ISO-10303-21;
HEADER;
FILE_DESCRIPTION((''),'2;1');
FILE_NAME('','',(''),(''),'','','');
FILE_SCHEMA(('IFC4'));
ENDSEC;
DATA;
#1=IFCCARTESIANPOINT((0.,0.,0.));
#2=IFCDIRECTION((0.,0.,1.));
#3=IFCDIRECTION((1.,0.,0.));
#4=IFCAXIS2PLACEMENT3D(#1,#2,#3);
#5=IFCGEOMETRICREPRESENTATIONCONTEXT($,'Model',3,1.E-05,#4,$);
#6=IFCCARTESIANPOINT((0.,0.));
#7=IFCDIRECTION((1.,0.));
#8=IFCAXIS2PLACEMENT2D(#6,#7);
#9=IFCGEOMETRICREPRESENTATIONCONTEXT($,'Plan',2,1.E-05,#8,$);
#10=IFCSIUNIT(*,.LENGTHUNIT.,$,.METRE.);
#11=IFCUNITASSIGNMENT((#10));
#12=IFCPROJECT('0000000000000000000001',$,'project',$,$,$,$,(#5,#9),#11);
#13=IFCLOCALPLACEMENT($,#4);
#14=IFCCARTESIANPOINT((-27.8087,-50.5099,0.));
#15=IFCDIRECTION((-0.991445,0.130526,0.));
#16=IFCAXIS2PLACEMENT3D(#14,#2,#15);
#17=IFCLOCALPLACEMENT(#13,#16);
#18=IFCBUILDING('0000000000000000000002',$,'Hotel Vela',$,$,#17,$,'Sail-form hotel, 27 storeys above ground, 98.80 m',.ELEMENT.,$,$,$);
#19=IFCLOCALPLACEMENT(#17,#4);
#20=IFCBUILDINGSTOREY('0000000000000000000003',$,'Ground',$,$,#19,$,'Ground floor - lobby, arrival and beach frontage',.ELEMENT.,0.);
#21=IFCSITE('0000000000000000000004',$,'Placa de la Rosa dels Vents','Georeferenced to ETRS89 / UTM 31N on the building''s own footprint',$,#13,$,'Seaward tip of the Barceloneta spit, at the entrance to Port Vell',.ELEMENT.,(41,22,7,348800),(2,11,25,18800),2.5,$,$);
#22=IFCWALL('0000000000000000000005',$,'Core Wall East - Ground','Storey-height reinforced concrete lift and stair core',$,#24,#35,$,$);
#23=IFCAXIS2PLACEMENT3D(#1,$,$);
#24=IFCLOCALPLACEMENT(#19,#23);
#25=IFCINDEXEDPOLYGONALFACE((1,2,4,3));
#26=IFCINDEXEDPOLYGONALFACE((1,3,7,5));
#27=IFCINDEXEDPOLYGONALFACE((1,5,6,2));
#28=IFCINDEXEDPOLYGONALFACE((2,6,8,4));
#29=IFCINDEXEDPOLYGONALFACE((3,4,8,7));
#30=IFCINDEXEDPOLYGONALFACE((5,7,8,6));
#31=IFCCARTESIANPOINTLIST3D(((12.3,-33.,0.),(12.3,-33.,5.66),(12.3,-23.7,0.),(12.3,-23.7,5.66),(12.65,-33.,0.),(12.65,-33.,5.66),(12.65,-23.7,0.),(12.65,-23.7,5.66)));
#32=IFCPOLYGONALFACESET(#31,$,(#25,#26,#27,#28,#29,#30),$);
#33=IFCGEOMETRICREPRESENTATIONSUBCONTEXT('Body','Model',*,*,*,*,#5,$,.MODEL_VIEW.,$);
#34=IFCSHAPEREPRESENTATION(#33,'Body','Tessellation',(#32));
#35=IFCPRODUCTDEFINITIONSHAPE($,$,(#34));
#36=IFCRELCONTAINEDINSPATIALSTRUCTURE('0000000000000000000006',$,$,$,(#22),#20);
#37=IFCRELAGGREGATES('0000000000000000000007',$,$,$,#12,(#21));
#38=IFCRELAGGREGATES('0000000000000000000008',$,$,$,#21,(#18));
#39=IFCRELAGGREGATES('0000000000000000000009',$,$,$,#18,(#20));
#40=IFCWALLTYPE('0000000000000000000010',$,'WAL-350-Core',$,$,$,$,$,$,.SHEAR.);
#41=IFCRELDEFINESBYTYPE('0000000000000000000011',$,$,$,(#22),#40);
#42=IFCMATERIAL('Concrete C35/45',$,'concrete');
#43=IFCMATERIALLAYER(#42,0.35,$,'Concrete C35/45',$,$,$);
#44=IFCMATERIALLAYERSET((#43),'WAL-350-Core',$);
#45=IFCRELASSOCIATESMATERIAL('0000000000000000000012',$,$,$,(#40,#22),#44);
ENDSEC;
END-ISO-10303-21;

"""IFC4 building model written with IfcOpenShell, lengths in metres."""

from ifc_helpers import new_model, si_unit, frame, origin_with_axes, origin_2d_with_axis, place, context, subcontext, project, spatial, line, indexed_curve, outline, extrude, material, layer, layer_set, layer_usage, type_object, element, save


model = new_model("IFC4")

# Units and contexts
model_context = context("Model", 3, precision=1e-05, world=origin_with_axes())
plan_context = context("Plan", 2, precision=1e-05, world=origin_2d_with_axis())
body_context = subcontext(model_context, "Body", "Model", "MODEL_VIEW")
ifc_project = project(units=[si_unit("LENGTHUNIT", "METRE")], contexts=[model_context, plan_context])

# Site, building, storey
site_placement = place(None, origin_with_axes())
site = spatial("IfcSite", under=ifc_project, at=site_placement, Name="Placa de la Rosa dels Vents", Description="Georeferenced to ETRS89 / UTM 31N on the building's own footprint", LongName="Seaward tip of the Barceloneta spit, at the entrance to Port Vell", CompositionType="ELEMENT", RefLatitude=(41, 22, 7, 348800), RefLongitude=(2, 11, 25, 18800), RefElevation=2.5)
building_placement = place(site_placement, frame((-27.8087, -50.5099, 0.0), z_axis=(0.0, 0.0, 1.0), x_axis=(-0.991445, 0.130526, 0.0)))
building = spatial("IfcBuilding", under=site, at=building_placement, Name="Hotel Vela", LongName="Sail-form hotel, 27 storeys above ground, 98.80 m", CompositionType="ELEMENT")
storey_placement = place(building_placement, origin_with_axes())
storey = spatial("IfcBuildingStorey", under=building, at=storey_placement, Name="Ground", LongName="Ground floor - lobby, arrival and beach frontage", CompositionType="ELEMENT", Elevation=0.0)

# Shared definitions
ifc_material = material(Name="Concrete C35/45", Category="concrete")

# Wall
ifc_layer_1 = layer(ifc_material, 0.35, Name="Concrete C35/45")
ifc_layer_set_1 = layer_set([ifc_layer_1], Name="WAL-350-Core")
wall_type = type_object("IfcWallType", Name="WAL-350-Core", PredefinedType="SHEAR", material=ifc_layer_set_1)
ifc_layer_usage_1 = layer_usage(ifc_layer_set_1, "AXIS2", "POSITIVE", 0.0)
wall_1_placement = place(storey_placement, frame((12.65, -33.0, 0.0), z_axis=(0.0, 0.0, 1.0), x_axis=(0.0, 1.0, 0.0)))
element("IfcWall", 1, at=wall_1_placement, inside=storey, type_object=wall_type, material=ifc_layer_usage_1, Name="Core Wall East - Ground", Description="Storey-height reinforced concrete lift and stair core", context=body_context, shape_type="SweptSolid", body=[
    extrude(outline(indexed_curve([(0.0, 0.0), (9.3, 0.0), (9.3, 0.35), (0.0, 0.35)], segments=[line(1, 2, 3, 4, 1)])), origin_with_axes(), (0.0, 0.0, 1.0), 5.66),
])

save(model, "model.ifc")
